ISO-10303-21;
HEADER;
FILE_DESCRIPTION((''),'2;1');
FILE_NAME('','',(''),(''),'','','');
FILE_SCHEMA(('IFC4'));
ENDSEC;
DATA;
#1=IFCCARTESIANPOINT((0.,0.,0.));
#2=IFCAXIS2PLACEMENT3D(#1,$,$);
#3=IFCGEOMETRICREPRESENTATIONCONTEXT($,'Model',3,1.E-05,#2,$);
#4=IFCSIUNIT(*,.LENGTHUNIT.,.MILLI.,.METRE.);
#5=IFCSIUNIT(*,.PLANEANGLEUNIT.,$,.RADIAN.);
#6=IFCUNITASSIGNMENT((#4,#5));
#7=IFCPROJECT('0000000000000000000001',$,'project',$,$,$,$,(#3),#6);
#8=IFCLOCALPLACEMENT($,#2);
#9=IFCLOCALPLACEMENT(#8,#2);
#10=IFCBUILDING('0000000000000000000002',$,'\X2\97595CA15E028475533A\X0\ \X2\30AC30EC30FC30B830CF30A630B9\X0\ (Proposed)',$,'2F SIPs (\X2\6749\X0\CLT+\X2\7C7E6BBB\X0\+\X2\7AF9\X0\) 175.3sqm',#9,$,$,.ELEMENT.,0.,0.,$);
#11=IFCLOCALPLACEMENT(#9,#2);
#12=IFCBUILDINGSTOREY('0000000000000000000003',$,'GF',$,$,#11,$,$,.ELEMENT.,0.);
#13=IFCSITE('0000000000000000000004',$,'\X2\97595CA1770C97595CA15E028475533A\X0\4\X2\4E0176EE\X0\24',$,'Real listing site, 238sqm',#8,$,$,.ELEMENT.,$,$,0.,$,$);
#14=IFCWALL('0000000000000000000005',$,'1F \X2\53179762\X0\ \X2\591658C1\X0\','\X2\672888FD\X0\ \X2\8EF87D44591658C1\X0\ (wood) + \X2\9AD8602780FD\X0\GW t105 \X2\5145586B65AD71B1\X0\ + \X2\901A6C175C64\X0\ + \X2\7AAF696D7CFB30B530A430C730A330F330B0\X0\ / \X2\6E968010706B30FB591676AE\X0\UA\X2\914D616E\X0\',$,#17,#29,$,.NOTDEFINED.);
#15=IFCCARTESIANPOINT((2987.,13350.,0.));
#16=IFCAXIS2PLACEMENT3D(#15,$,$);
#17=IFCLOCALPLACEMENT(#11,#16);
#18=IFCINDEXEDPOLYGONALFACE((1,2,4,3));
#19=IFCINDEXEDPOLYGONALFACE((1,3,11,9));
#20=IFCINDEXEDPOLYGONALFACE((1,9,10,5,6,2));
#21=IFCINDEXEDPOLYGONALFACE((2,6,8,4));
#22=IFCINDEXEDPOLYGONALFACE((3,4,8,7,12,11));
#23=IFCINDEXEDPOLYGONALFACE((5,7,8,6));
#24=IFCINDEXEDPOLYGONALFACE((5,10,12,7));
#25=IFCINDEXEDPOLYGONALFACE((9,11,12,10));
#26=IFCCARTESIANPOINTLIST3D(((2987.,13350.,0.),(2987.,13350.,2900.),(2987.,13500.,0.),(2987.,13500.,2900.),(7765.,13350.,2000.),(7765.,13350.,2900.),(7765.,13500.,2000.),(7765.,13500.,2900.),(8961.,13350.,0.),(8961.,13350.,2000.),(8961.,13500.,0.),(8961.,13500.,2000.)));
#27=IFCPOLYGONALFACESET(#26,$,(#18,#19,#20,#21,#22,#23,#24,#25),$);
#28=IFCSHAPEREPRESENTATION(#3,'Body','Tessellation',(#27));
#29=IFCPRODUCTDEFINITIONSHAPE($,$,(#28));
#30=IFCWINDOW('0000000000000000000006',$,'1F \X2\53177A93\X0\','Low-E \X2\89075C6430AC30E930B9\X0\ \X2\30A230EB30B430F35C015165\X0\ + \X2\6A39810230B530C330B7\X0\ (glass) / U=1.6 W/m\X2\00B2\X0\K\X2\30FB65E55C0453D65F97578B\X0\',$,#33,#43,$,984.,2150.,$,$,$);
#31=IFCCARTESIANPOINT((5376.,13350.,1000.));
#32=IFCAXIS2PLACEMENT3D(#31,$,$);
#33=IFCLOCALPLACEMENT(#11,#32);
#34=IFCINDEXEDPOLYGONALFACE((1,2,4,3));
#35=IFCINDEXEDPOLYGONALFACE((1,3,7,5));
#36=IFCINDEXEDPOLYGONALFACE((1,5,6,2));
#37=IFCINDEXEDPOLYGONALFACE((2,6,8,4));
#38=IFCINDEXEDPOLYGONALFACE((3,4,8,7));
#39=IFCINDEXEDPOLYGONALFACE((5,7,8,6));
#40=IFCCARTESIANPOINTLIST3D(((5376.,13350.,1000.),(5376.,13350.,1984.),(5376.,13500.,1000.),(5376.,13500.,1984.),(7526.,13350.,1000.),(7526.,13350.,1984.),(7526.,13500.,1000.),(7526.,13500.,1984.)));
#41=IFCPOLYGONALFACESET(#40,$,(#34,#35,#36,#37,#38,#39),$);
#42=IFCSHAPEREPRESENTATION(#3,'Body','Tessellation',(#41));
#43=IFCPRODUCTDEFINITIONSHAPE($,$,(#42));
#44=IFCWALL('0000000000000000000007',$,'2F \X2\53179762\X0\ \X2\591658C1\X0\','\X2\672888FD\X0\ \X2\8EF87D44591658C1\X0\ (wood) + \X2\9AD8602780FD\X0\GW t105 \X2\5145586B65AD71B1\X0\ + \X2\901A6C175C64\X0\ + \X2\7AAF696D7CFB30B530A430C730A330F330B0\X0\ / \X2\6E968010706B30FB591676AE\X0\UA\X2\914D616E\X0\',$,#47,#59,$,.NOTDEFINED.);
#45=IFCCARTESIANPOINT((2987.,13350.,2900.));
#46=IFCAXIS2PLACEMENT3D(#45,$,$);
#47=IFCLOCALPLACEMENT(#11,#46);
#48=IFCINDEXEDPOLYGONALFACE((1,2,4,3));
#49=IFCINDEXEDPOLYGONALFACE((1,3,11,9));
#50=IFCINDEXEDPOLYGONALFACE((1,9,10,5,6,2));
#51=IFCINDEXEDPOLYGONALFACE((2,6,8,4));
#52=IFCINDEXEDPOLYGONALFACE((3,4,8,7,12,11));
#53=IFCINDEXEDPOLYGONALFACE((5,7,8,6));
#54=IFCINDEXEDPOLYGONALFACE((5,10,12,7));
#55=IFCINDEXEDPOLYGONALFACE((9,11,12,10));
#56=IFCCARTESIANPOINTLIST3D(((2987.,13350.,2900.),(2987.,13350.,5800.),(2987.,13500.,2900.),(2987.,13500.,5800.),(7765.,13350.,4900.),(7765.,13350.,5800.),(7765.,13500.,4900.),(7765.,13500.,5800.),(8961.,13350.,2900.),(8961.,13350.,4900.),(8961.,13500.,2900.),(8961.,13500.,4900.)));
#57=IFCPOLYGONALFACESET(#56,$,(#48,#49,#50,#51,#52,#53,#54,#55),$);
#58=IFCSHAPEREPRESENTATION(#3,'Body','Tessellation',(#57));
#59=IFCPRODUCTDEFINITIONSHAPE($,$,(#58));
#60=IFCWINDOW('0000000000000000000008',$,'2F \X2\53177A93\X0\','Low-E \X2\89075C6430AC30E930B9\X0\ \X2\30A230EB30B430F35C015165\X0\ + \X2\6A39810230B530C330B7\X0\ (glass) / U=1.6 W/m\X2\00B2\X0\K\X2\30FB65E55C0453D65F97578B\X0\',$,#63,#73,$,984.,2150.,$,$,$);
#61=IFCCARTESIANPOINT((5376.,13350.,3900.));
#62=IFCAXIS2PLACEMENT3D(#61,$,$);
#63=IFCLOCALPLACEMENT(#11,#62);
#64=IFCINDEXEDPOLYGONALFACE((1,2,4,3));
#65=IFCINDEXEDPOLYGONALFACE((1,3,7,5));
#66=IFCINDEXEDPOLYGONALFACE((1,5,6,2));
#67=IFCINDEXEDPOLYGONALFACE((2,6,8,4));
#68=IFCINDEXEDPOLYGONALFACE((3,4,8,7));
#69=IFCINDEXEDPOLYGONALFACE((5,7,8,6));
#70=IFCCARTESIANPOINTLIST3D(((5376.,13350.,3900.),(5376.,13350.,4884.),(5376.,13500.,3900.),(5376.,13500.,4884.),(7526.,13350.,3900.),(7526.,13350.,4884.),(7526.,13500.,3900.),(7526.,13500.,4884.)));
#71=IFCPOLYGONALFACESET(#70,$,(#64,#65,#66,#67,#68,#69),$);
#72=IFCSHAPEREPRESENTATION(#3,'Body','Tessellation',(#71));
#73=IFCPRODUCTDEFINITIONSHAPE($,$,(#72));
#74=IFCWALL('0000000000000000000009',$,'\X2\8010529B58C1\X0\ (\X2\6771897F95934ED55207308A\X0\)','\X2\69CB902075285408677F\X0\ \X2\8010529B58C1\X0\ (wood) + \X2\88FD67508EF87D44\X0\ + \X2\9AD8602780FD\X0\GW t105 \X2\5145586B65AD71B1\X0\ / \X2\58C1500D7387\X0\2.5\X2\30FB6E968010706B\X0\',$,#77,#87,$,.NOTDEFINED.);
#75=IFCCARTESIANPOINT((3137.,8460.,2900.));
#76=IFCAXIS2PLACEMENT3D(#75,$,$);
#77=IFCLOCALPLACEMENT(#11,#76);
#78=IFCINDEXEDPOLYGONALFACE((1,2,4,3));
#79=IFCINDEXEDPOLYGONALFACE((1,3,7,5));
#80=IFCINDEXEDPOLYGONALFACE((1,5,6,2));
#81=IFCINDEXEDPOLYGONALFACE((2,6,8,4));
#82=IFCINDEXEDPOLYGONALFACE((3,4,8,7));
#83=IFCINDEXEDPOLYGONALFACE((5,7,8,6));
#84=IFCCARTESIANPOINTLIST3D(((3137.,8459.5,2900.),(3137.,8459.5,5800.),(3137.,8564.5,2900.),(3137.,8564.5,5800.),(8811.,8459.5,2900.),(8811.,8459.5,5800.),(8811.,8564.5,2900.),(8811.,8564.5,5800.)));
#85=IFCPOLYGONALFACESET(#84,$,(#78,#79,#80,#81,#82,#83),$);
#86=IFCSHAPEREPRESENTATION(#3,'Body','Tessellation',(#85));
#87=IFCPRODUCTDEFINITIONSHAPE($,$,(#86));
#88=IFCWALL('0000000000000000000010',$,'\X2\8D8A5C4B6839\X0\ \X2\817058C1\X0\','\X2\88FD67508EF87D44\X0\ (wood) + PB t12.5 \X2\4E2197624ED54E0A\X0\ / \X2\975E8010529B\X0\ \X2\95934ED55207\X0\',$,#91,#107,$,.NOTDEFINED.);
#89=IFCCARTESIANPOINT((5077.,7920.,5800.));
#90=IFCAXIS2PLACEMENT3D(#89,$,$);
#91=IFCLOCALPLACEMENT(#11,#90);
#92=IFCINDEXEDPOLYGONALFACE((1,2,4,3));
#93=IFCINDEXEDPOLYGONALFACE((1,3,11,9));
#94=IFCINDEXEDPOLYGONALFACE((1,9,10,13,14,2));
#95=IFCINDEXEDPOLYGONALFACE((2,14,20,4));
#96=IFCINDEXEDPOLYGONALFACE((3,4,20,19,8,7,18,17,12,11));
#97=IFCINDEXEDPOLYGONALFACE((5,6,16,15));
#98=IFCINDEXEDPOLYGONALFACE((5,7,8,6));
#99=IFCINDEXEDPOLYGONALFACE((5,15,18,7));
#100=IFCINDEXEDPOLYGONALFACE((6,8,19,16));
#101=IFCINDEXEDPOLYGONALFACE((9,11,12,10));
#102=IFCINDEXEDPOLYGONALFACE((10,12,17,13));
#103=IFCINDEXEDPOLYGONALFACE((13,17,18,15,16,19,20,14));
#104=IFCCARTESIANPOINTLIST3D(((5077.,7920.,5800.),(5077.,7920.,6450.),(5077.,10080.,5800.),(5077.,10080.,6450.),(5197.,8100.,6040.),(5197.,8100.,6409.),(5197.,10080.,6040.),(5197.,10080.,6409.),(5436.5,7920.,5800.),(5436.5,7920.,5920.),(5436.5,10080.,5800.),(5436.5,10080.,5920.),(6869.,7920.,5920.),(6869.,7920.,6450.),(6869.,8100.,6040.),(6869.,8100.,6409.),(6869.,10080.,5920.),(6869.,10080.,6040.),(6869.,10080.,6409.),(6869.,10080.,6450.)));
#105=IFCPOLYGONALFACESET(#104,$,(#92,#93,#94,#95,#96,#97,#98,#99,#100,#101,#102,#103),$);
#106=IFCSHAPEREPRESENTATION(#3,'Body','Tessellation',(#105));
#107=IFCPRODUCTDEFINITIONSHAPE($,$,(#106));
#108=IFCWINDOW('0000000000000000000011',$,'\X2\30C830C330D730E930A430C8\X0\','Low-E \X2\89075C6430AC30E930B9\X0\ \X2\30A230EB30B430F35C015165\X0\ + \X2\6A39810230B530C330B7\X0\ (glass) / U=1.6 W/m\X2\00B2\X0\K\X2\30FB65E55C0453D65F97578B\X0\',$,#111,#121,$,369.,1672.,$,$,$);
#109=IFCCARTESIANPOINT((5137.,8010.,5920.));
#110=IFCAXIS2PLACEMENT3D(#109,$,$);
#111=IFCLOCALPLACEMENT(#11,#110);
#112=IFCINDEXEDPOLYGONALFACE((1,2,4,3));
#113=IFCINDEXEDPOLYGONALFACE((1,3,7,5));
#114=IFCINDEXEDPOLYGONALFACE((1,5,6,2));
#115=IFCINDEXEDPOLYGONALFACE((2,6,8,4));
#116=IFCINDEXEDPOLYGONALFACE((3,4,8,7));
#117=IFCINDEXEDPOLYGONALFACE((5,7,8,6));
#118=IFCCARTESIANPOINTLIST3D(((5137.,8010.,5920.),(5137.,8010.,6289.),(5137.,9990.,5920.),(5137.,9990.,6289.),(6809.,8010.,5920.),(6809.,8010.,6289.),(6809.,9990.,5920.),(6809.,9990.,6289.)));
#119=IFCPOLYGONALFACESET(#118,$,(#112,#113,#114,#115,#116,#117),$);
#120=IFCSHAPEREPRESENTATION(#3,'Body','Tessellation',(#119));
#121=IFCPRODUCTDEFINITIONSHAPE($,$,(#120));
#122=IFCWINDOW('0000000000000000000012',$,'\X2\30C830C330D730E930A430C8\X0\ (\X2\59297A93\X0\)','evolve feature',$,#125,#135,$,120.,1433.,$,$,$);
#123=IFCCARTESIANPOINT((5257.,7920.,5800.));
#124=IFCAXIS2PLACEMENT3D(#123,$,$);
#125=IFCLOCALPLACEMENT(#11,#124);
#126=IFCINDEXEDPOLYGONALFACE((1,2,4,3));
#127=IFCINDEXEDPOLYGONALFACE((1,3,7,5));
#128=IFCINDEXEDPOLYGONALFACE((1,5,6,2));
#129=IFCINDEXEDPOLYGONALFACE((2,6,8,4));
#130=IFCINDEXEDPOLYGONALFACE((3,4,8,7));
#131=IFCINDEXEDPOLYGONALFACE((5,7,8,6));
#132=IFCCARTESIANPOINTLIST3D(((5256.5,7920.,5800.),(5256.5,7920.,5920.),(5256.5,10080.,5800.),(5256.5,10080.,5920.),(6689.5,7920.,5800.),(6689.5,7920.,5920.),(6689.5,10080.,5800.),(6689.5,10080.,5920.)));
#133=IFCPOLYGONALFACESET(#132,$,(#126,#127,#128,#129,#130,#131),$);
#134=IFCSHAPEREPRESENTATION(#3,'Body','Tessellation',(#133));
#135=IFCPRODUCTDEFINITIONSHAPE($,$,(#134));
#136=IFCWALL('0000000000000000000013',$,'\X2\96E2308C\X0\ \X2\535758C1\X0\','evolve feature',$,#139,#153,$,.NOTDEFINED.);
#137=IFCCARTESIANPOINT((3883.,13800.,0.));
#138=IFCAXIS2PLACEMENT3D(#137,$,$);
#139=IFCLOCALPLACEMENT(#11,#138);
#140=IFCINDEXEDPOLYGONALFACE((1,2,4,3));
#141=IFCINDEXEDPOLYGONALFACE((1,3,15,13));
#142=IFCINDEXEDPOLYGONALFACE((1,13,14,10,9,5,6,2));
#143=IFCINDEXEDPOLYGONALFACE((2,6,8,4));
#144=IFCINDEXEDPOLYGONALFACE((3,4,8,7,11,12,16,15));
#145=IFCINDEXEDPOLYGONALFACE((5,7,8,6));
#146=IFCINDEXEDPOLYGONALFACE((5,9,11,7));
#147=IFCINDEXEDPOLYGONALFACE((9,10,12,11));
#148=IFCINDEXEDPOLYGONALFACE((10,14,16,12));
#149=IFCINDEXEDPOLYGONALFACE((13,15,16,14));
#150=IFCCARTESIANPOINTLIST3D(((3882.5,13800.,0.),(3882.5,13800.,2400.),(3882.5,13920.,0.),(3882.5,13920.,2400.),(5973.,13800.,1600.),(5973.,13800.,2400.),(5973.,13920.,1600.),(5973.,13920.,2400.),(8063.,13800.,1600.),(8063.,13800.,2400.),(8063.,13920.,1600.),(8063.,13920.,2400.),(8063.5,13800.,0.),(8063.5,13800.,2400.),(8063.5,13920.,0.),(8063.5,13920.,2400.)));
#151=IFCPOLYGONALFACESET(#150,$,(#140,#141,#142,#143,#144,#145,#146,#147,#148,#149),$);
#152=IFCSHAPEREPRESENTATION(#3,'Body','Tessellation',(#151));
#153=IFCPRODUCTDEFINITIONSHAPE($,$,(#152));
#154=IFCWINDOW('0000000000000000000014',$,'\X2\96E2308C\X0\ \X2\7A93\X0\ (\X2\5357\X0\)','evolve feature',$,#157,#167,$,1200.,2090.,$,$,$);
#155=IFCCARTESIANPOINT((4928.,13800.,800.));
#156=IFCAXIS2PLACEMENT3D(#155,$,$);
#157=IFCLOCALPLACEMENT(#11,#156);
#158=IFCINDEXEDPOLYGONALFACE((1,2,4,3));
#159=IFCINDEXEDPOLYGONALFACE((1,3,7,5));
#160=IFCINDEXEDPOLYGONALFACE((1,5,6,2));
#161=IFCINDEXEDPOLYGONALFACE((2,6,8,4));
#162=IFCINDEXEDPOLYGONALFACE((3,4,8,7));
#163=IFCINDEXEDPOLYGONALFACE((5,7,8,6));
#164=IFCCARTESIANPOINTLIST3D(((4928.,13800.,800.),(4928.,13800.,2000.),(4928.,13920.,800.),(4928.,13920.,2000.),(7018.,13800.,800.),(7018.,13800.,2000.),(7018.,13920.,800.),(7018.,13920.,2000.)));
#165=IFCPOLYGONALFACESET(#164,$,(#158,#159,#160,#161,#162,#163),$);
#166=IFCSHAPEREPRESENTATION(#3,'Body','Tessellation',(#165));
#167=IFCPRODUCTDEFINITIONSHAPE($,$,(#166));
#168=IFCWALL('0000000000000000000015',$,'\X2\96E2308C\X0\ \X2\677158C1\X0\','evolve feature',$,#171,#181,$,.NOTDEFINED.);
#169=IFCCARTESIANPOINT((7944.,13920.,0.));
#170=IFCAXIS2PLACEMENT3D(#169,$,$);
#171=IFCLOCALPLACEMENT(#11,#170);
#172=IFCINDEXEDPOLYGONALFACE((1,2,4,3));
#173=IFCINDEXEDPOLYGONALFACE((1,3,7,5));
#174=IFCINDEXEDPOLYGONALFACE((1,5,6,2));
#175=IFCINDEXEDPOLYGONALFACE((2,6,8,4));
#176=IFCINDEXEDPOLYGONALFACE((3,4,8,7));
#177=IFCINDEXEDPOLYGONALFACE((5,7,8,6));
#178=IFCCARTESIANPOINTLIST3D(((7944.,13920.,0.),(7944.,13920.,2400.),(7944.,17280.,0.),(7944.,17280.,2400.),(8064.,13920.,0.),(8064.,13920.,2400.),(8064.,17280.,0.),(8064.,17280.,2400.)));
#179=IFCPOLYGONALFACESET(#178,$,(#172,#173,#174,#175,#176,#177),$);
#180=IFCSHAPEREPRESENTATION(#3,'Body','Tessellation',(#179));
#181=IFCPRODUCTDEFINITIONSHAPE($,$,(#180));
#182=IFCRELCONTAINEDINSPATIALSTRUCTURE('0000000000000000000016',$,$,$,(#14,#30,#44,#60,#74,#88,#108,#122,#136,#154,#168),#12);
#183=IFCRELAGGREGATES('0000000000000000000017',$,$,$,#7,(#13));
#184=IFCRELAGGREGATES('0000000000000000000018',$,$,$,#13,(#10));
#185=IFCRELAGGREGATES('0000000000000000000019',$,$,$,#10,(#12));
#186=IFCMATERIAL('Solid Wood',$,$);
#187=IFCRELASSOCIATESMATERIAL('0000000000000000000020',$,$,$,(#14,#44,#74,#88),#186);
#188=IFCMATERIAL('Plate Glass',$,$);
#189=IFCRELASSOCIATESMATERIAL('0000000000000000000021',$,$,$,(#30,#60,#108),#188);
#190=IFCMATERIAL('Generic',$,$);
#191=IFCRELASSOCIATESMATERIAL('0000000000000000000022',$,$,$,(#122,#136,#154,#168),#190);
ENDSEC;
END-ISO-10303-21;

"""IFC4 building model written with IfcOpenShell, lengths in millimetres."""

from ifc_helpers import new_model, si_unit, frame, frame_2d, origin, place, context, project, spatial, rectangle, extrude, material, element, fill, save


model = new_model("IFC4")

# Units and contexts
model_context = context("Model", 3, precision=1e-05, world=origin())
ifc_project = project(units=[si_unit("LENGTHUNIT", "METRE", prefix="MILLI"), si_unit("PLANEANGLEUNIT", "RADIAN")], contexts=[model_context])

# Site, building, storey
site_placement = place(None, origin())
site = spatial("IfcSite", under=ifc_project, at=site_placement, Name="静岡県静岡市葵区4丁目24", ObjectType="Real listing site, 238sqm", CompositionType="ELEMENT", RefElevation=0.0)
building_placement = place(site_placement, origin())
building = spatial("IfcBuilding", under=site, at=building_placement, Name="静岡市葵区 ガレージハウス (Proposed)", ObjectType="2F SIPs (杉CLT+籾殻+竹) 175.3sqm", CompositionType="ELEMENT", ElevationOfRefHeight=0.0, ElevationOfTerrain=0.0)
storey_placement = place(building_placement, origin())
storey = spatial("IfcBuildingStorey", under=building, at=storey_placement, Name="GF", CompositionType="ELEMENT", Elevation=0.0)

# Shared definitions
ifc_material_1 = material(Name="Generic")

# Wall, opening, window
ifc_material_2 = material(Name="Solid Wood")
wall_1_placement = place(storey_placement, frame((2987.0, 13350.0, 0.0)))
wall_1 = element("IfcWall", 1, at=wall_1_placement, inside=storey, material=ifc_material_2, Name="1F 北面 外壁", Description="木製 軸組外壁 (wood) + 高性能GW t105 充填断熱 + 通気層 + 窯業系サイディング / 準耐火・外皮UA配慮", PredefinedType="NOTDEFINED", context=model_context, shape_type="SweptSolid", body=[
    extrude(rectangle(XDim=5974.0, YDim=150.0, at=frame_2d((2987.0, 75.0))), frame((2987.0, 13350.0, 0.0)), (0.0, 0.0, 1.0), 2900.0),
])
opening_1_placement = place(storey_placement, frame((5376.0, 13350.0, 1000.0)))
opening_1 = element("IfcOpeningElement", 2, at=opening_1_placement, cuts=wall_1, PredefinedType="NOTDEFINED", context=model_context, shape_type="SweptSolid", body=[
    extrude(rectangle(XDim=2150.0, YDim=150.0, at=frame_2d((1075.0, 75.0))), frame((5376.0, 13350.0, 1000.0)), (0.0, 0.0, 1.0), 984.0),
])
ifc_material_3 = material(Name="Plate Glass")
window_1_placement = place(storey_placement, frame((5376.0, 13350.0, 1000.0)))
window_1 = element("IfcWindow", 3, at=window_1_placement, inside=storey, material=ifc_material_3, Name="1F 北窓", Description="Low-E 複層ガラス アルゴン封入 + 樹脂サッシ (glass) / U=1.6 W/m²K・日射取得型", OverallHeight=984.0, OverallWidth=2150.0, context=model_context, shape_type="SweptSolid", body=[
    extrude(rectangle(XDim=2150.0, YDim=150.0, at=frame_2d((1075.0, 75.0))), frame((5376.0, 13350.0, 1000.0)), (0.0, 0.0, 1.0), 984.0),
])
fill(opening_1, window_1)

# Wall, opening, window
wall_2_placement = place(storey_placement, frame((2987.0, 13350.0, 2900.0)))
wall_2 = element("IfcWall", 4, at=wall_2_placement, inside=storey, material=ifc_material_2, Name="2F 北面 外壁", Description="木製 軸組外壁 (wood) + 高性能GW t105 充填断熱 + 通気層 + 窯業系サイディング / 準耐火・外皮UA配慮", PredefinedType="NOTDEFINED", context=model_context, shape_type="SweptSolid", body=[
    extrude(rectangle(XDim=5974.0, YDim=150.0, at=frame_2d((2987.0, 75.0))), frame((2987.0, 13350.0, 2900.0)), (0.0, 0.0, 1.0), 2900.0),
])
opening_2_placement = place(storey_placement, frame((5376.0, 13350.0, 3900.0)))
opening_2 = element("IfcOpeningElement", 5, at=opening_2_placement, cuts=wall_2, PredefinedType="NOTDEFINED", context=model_context, shape_type="SweptSolid", body=[
    extrude(rectangle(XDim=2150.0, YDim=150.0, at=frame_2d((1075.0, 75.0))), frame((5376.0, 13350.0, 3900.0)), (0.0, 0.0, 1.0), 984.0),
])
window_2_placement = place(storey_placement, frame((5376.0, 13350.0, 3900.0)))
window_2 = element("IfcWindow", 6, at=window_2_placement, inside=storey, material=ifc_material_3, Name="2F 北窓", Description="Low-E 複層ガラス アルゴン封入 + 樹脂サッシ (glass) / U=1.6 W/m²K・日射取得型", OverallHeight=984.0, OverallWidth=2150.0, context=model_context, shape_type="SweptSolid", body=[
    extrude(rectangle(XDim=2150.0, YDim=150.0, at=frame_2d((1075.0, 75.0))), frame((5376.0, 13350.0, 3900.0)), (0.0, 0.0, 1.0), 984.0),
])
fill(opening_2, window_2)

# Wall
wall_3_placement = place(storey_placement, frame((3137.0, 8460.0, 2900.0)))
element("IfcWall", 7, at=wall_3_placement, inside=storey, material=ifc_material_2, Name="耐力壁 (東西間仕切り)", Description="構造用合板 耐力壁 (wood) + 製材軸組 + 高性能GW t105 充填断熱 / 壁倍率2.5・準耐火", PredefinedType="NOTDEFINED", context=model_context, shape_type="SweptSolid", body=[
    extrude(rectangle(XDim=5674.0, YDim=105.0, at=frame_2d((2837.0, 52.0))), frame((3137.0, 8460.0, 2900.0)), (0.0, 0.0, 1.0), 2900.0),
])

# Wall, openings, windows
wall_4_placement = place(storey_placement, frame((5077.0, 7920.0, 5800.0)))
wall_4 = element("IfcWall", 8, at=wall_4_placement, inside=storey, material=ifc_material_2, Name="越屋根 腰壁", Description="製材軸組 (wood) + PB t12.5 両面仕上 / 非耐力 間仕切", PredefinedType="NOTDEFINED", context=model_context, shape_type="SweptSolid", body=[
    extrude(rectangle(XDim=1792.0, YDim=2160.0, at=frame_2d((896.0, 1080.0))), frame((5077.0, 7920.0, 5800.0)), (0.0, 0.0, 1.0), 650.0),
])
opening_3_placement = place(storey_placement, frame((5137.0, 8010.0, 5920.0)))
opening_3 = element("IfcOpeningElement", 9, at=opening_3_placement, cuts=wall_4, PredefinedType="NOTDEFINED", context=model_context, shape_type="SweptSolid", body=[
    extrude(rectangle(XDim=1672.0, YDim=1980.0, at=frame_2d((836.0, 990.0))), frame((5137.0, 8010.0, 5920.0)), (0.0, 0.0, 1.0), 369.0),
])
opening_4_placement = place(storey_placement, frame((5257.0, 7920.0, 5800.0)))
opening_4 = element("IfcOpeningElement", 10, at=opening_4_placement, cuts=wall_4, PredefinedType="NOTDEFINED", context=model_context, shape_type="SweptSolid", body=[
    extrude(rectangle(XDim=1433.0, YDim=2160.0, at=frame_2d((716.0, 1080.0))), frame((5257.0, 7920.0, 5800.0)), (0.0, 0.0, 1.0), 120.0),
])
window_3_placement = place(storey_placement, frame((5137.0, 8010.0, 5920.0)))
window_3 = element("IfcWindow", 11, at=window_3_placement, inside=storey, material=ifc_material_3, Name="トップライト", Description="Low-E 複層ガラス アルゴン封入 + 樹脂サッシ (glass) / U=1.6 W/m²K・日射取得型", OverallHeight=369.0, OverallWidth=1672.0, context=model_context, shape_type="SweptSolid", body=[
    extrude(rectangle(XDim=1672.0, YDim=1980.0, at=frame_2d((836.0, 990.0))), frame((5137.0, 8010.0, 5920.0)), (0.0, 0.0, 1.0), 369.0),
])
fill(opening_3, window_3)
window_4_placement = place(storey_placement, frame((5257.0, 7920.0, 5800.0)))
window_4 = element("IfcWindow", 12, at=window_4_placement, inside=storey, material=ifc_material_1, Name="トップライト (天窓)", Description="evolve feature", OverallHeight=120.0, OverallWidth=1433.0, context=model_context, shape_type="SweptSolid", body=[
    extrude(rectangle(XDim=1433.0, YDim=2160.0, at=frame_2d((716.0, 1080.0))), frame((5257.0, 7920.0, 5800.0)), (0.0, 0.0, 1.0), 120.0),
])
fill(opening_4, window_4)

# Wall, opening, window
wall_5_placement = place(storey_placement, frame((3883.0, 13800.0, 0.0)))
wall_5 = element("IfcWall", 13, at=wall_5_placement, inside=storey, material=ifc_material_1, Name="離れ 南壁", Description="evolve feature", PredefinedType="NOTDEFINED", context=model_context, shape_type="SweptSolid", body=[
    extrude(rectangle(XDim=4181.0, YDim=120.0, at=frame_2d((2090.0, 60.0))), frame((3883.0, 13800.0, 0.0)), (0.0, 0.0, 1.0), 2400.0),
])
opening_5_placement = place(storey_placement, frame((4928.0, 13800.0, 800.0)))
opening_5 = element("IfcOpeningElement", 14, at=opening_5_placement, cuts=wall_5, PredefinedType="NOTDEFINED", context=model_context, shape_type="SweptSolid", body=[
    extrude(rectangle(XDim=2090.0, YDim=120.0, at=frame_2d((1045.0, 60.0))), frame((4928.0, 13800.0, 800.0)), (0.0, 0.0, 1.0), 1200.0),
])
window_5_placement = place(storey_placement, frame((4928.0, 13800.0, 800.0)))
window_5 = element("IfcWindow", 15, at=window_5_placement, inside=storey, material=ifc_material_1, Name="離れ 窓 (南)", Description="evolve feature", OverallHeight=1200.0, OverallWidth=2090.0, context=model_context, shape_type="SweptSolid", body=[
    extrude(rectangle(XDim=2090.0, YDim=120.0, at=frame_2d((1045.0, 60.0))), frame((4928.0, 13800.0, 800.0)), (0.0, 0.0, 1.0), 1200.0),
])
fill(opening_5, window_5)

# Wall
wall_6_placement = place(storey_placement, frame((7944.0, 13920.0, 0.0)))
element("IfcWall", 16, at=wall_6_placement, inside=storey, material=ifc_material_1, Name="離れ 東壁", Description="evolve feature", PredefinedType="NOTDEFINED", context=model_context, shape_type="SweptSolid", body=[
    extrude(rectangle(XDim=120.0, YDim=3360.0, at=frame_2d((60.0, 1680.0))), frame((7944.0, 13920.0, 0.0)), (0.0, 0.0, 1.0), 2400.0),
])

save(model, "model.ifc")
